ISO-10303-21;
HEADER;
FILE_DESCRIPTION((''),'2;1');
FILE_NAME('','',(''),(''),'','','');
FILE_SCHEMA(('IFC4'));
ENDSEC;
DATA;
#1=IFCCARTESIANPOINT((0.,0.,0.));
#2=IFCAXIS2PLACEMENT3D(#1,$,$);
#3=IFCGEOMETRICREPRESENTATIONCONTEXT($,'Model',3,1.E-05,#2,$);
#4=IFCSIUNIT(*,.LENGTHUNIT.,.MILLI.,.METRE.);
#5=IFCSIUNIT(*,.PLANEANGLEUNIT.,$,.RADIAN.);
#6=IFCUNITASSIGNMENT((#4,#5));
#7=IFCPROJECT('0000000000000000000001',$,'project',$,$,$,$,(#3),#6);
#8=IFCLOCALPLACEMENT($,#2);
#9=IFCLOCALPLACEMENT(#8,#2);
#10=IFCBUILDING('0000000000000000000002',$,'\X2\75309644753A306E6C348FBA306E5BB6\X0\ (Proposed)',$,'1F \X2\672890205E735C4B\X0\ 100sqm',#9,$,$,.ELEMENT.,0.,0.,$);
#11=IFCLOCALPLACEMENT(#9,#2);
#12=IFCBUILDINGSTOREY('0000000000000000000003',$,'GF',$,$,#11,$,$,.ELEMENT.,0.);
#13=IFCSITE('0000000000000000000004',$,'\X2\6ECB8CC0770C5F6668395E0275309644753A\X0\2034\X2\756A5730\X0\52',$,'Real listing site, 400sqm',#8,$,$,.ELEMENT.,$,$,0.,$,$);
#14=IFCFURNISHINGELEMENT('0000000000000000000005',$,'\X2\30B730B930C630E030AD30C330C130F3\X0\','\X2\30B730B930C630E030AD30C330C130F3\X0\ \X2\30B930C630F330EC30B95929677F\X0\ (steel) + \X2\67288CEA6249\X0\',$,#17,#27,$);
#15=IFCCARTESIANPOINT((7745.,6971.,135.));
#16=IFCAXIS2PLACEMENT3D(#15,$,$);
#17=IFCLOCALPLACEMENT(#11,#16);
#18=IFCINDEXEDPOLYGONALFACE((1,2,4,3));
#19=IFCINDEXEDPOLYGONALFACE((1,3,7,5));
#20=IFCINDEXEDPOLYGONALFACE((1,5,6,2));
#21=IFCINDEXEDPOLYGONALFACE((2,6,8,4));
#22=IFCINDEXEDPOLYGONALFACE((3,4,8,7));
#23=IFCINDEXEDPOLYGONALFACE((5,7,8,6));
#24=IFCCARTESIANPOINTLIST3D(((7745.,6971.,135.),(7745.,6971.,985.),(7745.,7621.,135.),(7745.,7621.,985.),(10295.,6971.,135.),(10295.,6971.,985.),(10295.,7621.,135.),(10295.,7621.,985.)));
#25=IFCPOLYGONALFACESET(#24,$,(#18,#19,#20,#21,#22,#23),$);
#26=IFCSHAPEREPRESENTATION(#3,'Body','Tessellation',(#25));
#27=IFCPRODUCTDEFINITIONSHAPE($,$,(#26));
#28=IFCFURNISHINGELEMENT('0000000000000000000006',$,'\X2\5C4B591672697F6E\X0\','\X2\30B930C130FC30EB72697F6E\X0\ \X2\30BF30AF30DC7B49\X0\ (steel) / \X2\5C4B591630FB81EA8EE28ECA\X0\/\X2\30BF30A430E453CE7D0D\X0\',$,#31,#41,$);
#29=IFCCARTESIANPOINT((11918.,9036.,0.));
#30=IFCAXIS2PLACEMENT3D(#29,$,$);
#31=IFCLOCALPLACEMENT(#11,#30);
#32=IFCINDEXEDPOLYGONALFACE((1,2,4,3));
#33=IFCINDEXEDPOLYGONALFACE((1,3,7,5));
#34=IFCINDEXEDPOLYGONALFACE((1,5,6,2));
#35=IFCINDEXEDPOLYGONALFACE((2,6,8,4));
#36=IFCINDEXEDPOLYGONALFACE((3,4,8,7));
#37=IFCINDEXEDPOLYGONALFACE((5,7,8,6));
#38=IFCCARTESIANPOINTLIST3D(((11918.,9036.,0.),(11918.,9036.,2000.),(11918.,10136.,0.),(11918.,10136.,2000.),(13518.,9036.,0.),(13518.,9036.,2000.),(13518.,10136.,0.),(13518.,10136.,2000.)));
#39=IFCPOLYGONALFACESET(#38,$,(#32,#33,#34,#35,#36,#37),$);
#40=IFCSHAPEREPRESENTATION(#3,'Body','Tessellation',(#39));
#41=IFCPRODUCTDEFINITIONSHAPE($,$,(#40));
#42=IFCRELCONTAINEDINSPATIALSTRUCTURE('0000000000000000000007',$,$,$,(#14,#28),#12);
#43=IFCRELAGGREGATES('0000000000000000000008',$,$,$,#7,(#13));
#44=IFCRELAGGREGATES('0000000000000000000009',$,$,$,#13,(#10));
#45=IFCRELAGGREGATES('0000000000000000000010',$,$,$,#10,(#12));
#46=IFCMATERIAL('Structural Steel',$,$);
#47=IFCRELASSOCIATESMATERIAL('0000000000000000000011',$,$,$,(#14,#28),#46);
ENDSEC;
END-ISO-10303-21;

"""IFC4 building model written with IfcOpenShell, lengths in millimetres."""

from ifc_helpers import new_model, si_unit, frame, frame_2d, origin, place, context, project, spatial, rectangle, extrude, material, element, save


model = new_model("IFC4")

# Units and contexts
model_context = context("Model", 3, precision=1e-05, world=origin())
ifc_project = project(units=[si_unit("LENGTHUNIT", "METRE", prefix="MILLI"), si_unit("PLANEANGLEUNIT", "RADIAN")], contexts=[model_context])

# Site, building, storey
site_placement = place(None, origin())
site = spatial("IfcSite", under=ifc_project, at=site_placement, Name="滋賀県彦根市田附町2034番地52", ObjectType="Real listing site, 400sqm", CompositionType="ELEMENT", RefElevation=0.0)
building_placement = place(site_placement, origin())
building = spatial("IfcBuilding", under=site, at=building_placement, Name="田附町の水辺の家 (Proposed)", ObjectType="1F 木造平屋 100sqm", CompositionType="ELEMENT", ElevationOfRefHeight=0.0, ElevationOfTerrain=0.0)
storey_placement = place(building_placement, origin())
storey = spatial("IfcBuildingStorey", under=building, at=storey_placement, Name="GF", CompositionType="ELEMENT", Elevation=0.0)

# Shared definitions
ifc_material_1 = material(Name="Structural Steel")

# Furnishing elements
furnishing_1_placement = place(storey_placement, frame((7745.0, 6971.0, 135.0)))
element("IfcFurnishingElement", 1, at=furnishing_1_placement, inside=storey, material=ifc_material_1, Name="システムキッチン", Description="システムキッチン ステンレス天板 (steel) + 木質扉", context=model_context, shape_type="SweptSolid", body=[
    extrude(rectangle(XDim=2550.0, YDim=650.0, at=frame_2d((1275.0, 325.0))), frame((7745.0, 6971.0, 135.0)), (0.0, 0.0, 1.0), 850.0),
])
furnishing_2_placement = place(storey_placement, frame((11918.0, 9036.0, 0.0)))
element("IfcFurnishingElement", 2, at=furnishing_2_placement, inside=storey, material=ifc_material_1, Name="屋外物置", Description="スチール物置 タクボ等 (steel) / 屋外・自転車/タイヤ収納", context=model_context, shape_type="SweptSolid", body=[
    extrude(rectangle(XDim=1600.0, YDim=1100.0, at=frame_2d((800.0, 550.0))), frame((11918.0, 9036.0, 0.0)), (0.0, 0.0, 1.0), 2000.0),
])

save(model, "model.ifc")
